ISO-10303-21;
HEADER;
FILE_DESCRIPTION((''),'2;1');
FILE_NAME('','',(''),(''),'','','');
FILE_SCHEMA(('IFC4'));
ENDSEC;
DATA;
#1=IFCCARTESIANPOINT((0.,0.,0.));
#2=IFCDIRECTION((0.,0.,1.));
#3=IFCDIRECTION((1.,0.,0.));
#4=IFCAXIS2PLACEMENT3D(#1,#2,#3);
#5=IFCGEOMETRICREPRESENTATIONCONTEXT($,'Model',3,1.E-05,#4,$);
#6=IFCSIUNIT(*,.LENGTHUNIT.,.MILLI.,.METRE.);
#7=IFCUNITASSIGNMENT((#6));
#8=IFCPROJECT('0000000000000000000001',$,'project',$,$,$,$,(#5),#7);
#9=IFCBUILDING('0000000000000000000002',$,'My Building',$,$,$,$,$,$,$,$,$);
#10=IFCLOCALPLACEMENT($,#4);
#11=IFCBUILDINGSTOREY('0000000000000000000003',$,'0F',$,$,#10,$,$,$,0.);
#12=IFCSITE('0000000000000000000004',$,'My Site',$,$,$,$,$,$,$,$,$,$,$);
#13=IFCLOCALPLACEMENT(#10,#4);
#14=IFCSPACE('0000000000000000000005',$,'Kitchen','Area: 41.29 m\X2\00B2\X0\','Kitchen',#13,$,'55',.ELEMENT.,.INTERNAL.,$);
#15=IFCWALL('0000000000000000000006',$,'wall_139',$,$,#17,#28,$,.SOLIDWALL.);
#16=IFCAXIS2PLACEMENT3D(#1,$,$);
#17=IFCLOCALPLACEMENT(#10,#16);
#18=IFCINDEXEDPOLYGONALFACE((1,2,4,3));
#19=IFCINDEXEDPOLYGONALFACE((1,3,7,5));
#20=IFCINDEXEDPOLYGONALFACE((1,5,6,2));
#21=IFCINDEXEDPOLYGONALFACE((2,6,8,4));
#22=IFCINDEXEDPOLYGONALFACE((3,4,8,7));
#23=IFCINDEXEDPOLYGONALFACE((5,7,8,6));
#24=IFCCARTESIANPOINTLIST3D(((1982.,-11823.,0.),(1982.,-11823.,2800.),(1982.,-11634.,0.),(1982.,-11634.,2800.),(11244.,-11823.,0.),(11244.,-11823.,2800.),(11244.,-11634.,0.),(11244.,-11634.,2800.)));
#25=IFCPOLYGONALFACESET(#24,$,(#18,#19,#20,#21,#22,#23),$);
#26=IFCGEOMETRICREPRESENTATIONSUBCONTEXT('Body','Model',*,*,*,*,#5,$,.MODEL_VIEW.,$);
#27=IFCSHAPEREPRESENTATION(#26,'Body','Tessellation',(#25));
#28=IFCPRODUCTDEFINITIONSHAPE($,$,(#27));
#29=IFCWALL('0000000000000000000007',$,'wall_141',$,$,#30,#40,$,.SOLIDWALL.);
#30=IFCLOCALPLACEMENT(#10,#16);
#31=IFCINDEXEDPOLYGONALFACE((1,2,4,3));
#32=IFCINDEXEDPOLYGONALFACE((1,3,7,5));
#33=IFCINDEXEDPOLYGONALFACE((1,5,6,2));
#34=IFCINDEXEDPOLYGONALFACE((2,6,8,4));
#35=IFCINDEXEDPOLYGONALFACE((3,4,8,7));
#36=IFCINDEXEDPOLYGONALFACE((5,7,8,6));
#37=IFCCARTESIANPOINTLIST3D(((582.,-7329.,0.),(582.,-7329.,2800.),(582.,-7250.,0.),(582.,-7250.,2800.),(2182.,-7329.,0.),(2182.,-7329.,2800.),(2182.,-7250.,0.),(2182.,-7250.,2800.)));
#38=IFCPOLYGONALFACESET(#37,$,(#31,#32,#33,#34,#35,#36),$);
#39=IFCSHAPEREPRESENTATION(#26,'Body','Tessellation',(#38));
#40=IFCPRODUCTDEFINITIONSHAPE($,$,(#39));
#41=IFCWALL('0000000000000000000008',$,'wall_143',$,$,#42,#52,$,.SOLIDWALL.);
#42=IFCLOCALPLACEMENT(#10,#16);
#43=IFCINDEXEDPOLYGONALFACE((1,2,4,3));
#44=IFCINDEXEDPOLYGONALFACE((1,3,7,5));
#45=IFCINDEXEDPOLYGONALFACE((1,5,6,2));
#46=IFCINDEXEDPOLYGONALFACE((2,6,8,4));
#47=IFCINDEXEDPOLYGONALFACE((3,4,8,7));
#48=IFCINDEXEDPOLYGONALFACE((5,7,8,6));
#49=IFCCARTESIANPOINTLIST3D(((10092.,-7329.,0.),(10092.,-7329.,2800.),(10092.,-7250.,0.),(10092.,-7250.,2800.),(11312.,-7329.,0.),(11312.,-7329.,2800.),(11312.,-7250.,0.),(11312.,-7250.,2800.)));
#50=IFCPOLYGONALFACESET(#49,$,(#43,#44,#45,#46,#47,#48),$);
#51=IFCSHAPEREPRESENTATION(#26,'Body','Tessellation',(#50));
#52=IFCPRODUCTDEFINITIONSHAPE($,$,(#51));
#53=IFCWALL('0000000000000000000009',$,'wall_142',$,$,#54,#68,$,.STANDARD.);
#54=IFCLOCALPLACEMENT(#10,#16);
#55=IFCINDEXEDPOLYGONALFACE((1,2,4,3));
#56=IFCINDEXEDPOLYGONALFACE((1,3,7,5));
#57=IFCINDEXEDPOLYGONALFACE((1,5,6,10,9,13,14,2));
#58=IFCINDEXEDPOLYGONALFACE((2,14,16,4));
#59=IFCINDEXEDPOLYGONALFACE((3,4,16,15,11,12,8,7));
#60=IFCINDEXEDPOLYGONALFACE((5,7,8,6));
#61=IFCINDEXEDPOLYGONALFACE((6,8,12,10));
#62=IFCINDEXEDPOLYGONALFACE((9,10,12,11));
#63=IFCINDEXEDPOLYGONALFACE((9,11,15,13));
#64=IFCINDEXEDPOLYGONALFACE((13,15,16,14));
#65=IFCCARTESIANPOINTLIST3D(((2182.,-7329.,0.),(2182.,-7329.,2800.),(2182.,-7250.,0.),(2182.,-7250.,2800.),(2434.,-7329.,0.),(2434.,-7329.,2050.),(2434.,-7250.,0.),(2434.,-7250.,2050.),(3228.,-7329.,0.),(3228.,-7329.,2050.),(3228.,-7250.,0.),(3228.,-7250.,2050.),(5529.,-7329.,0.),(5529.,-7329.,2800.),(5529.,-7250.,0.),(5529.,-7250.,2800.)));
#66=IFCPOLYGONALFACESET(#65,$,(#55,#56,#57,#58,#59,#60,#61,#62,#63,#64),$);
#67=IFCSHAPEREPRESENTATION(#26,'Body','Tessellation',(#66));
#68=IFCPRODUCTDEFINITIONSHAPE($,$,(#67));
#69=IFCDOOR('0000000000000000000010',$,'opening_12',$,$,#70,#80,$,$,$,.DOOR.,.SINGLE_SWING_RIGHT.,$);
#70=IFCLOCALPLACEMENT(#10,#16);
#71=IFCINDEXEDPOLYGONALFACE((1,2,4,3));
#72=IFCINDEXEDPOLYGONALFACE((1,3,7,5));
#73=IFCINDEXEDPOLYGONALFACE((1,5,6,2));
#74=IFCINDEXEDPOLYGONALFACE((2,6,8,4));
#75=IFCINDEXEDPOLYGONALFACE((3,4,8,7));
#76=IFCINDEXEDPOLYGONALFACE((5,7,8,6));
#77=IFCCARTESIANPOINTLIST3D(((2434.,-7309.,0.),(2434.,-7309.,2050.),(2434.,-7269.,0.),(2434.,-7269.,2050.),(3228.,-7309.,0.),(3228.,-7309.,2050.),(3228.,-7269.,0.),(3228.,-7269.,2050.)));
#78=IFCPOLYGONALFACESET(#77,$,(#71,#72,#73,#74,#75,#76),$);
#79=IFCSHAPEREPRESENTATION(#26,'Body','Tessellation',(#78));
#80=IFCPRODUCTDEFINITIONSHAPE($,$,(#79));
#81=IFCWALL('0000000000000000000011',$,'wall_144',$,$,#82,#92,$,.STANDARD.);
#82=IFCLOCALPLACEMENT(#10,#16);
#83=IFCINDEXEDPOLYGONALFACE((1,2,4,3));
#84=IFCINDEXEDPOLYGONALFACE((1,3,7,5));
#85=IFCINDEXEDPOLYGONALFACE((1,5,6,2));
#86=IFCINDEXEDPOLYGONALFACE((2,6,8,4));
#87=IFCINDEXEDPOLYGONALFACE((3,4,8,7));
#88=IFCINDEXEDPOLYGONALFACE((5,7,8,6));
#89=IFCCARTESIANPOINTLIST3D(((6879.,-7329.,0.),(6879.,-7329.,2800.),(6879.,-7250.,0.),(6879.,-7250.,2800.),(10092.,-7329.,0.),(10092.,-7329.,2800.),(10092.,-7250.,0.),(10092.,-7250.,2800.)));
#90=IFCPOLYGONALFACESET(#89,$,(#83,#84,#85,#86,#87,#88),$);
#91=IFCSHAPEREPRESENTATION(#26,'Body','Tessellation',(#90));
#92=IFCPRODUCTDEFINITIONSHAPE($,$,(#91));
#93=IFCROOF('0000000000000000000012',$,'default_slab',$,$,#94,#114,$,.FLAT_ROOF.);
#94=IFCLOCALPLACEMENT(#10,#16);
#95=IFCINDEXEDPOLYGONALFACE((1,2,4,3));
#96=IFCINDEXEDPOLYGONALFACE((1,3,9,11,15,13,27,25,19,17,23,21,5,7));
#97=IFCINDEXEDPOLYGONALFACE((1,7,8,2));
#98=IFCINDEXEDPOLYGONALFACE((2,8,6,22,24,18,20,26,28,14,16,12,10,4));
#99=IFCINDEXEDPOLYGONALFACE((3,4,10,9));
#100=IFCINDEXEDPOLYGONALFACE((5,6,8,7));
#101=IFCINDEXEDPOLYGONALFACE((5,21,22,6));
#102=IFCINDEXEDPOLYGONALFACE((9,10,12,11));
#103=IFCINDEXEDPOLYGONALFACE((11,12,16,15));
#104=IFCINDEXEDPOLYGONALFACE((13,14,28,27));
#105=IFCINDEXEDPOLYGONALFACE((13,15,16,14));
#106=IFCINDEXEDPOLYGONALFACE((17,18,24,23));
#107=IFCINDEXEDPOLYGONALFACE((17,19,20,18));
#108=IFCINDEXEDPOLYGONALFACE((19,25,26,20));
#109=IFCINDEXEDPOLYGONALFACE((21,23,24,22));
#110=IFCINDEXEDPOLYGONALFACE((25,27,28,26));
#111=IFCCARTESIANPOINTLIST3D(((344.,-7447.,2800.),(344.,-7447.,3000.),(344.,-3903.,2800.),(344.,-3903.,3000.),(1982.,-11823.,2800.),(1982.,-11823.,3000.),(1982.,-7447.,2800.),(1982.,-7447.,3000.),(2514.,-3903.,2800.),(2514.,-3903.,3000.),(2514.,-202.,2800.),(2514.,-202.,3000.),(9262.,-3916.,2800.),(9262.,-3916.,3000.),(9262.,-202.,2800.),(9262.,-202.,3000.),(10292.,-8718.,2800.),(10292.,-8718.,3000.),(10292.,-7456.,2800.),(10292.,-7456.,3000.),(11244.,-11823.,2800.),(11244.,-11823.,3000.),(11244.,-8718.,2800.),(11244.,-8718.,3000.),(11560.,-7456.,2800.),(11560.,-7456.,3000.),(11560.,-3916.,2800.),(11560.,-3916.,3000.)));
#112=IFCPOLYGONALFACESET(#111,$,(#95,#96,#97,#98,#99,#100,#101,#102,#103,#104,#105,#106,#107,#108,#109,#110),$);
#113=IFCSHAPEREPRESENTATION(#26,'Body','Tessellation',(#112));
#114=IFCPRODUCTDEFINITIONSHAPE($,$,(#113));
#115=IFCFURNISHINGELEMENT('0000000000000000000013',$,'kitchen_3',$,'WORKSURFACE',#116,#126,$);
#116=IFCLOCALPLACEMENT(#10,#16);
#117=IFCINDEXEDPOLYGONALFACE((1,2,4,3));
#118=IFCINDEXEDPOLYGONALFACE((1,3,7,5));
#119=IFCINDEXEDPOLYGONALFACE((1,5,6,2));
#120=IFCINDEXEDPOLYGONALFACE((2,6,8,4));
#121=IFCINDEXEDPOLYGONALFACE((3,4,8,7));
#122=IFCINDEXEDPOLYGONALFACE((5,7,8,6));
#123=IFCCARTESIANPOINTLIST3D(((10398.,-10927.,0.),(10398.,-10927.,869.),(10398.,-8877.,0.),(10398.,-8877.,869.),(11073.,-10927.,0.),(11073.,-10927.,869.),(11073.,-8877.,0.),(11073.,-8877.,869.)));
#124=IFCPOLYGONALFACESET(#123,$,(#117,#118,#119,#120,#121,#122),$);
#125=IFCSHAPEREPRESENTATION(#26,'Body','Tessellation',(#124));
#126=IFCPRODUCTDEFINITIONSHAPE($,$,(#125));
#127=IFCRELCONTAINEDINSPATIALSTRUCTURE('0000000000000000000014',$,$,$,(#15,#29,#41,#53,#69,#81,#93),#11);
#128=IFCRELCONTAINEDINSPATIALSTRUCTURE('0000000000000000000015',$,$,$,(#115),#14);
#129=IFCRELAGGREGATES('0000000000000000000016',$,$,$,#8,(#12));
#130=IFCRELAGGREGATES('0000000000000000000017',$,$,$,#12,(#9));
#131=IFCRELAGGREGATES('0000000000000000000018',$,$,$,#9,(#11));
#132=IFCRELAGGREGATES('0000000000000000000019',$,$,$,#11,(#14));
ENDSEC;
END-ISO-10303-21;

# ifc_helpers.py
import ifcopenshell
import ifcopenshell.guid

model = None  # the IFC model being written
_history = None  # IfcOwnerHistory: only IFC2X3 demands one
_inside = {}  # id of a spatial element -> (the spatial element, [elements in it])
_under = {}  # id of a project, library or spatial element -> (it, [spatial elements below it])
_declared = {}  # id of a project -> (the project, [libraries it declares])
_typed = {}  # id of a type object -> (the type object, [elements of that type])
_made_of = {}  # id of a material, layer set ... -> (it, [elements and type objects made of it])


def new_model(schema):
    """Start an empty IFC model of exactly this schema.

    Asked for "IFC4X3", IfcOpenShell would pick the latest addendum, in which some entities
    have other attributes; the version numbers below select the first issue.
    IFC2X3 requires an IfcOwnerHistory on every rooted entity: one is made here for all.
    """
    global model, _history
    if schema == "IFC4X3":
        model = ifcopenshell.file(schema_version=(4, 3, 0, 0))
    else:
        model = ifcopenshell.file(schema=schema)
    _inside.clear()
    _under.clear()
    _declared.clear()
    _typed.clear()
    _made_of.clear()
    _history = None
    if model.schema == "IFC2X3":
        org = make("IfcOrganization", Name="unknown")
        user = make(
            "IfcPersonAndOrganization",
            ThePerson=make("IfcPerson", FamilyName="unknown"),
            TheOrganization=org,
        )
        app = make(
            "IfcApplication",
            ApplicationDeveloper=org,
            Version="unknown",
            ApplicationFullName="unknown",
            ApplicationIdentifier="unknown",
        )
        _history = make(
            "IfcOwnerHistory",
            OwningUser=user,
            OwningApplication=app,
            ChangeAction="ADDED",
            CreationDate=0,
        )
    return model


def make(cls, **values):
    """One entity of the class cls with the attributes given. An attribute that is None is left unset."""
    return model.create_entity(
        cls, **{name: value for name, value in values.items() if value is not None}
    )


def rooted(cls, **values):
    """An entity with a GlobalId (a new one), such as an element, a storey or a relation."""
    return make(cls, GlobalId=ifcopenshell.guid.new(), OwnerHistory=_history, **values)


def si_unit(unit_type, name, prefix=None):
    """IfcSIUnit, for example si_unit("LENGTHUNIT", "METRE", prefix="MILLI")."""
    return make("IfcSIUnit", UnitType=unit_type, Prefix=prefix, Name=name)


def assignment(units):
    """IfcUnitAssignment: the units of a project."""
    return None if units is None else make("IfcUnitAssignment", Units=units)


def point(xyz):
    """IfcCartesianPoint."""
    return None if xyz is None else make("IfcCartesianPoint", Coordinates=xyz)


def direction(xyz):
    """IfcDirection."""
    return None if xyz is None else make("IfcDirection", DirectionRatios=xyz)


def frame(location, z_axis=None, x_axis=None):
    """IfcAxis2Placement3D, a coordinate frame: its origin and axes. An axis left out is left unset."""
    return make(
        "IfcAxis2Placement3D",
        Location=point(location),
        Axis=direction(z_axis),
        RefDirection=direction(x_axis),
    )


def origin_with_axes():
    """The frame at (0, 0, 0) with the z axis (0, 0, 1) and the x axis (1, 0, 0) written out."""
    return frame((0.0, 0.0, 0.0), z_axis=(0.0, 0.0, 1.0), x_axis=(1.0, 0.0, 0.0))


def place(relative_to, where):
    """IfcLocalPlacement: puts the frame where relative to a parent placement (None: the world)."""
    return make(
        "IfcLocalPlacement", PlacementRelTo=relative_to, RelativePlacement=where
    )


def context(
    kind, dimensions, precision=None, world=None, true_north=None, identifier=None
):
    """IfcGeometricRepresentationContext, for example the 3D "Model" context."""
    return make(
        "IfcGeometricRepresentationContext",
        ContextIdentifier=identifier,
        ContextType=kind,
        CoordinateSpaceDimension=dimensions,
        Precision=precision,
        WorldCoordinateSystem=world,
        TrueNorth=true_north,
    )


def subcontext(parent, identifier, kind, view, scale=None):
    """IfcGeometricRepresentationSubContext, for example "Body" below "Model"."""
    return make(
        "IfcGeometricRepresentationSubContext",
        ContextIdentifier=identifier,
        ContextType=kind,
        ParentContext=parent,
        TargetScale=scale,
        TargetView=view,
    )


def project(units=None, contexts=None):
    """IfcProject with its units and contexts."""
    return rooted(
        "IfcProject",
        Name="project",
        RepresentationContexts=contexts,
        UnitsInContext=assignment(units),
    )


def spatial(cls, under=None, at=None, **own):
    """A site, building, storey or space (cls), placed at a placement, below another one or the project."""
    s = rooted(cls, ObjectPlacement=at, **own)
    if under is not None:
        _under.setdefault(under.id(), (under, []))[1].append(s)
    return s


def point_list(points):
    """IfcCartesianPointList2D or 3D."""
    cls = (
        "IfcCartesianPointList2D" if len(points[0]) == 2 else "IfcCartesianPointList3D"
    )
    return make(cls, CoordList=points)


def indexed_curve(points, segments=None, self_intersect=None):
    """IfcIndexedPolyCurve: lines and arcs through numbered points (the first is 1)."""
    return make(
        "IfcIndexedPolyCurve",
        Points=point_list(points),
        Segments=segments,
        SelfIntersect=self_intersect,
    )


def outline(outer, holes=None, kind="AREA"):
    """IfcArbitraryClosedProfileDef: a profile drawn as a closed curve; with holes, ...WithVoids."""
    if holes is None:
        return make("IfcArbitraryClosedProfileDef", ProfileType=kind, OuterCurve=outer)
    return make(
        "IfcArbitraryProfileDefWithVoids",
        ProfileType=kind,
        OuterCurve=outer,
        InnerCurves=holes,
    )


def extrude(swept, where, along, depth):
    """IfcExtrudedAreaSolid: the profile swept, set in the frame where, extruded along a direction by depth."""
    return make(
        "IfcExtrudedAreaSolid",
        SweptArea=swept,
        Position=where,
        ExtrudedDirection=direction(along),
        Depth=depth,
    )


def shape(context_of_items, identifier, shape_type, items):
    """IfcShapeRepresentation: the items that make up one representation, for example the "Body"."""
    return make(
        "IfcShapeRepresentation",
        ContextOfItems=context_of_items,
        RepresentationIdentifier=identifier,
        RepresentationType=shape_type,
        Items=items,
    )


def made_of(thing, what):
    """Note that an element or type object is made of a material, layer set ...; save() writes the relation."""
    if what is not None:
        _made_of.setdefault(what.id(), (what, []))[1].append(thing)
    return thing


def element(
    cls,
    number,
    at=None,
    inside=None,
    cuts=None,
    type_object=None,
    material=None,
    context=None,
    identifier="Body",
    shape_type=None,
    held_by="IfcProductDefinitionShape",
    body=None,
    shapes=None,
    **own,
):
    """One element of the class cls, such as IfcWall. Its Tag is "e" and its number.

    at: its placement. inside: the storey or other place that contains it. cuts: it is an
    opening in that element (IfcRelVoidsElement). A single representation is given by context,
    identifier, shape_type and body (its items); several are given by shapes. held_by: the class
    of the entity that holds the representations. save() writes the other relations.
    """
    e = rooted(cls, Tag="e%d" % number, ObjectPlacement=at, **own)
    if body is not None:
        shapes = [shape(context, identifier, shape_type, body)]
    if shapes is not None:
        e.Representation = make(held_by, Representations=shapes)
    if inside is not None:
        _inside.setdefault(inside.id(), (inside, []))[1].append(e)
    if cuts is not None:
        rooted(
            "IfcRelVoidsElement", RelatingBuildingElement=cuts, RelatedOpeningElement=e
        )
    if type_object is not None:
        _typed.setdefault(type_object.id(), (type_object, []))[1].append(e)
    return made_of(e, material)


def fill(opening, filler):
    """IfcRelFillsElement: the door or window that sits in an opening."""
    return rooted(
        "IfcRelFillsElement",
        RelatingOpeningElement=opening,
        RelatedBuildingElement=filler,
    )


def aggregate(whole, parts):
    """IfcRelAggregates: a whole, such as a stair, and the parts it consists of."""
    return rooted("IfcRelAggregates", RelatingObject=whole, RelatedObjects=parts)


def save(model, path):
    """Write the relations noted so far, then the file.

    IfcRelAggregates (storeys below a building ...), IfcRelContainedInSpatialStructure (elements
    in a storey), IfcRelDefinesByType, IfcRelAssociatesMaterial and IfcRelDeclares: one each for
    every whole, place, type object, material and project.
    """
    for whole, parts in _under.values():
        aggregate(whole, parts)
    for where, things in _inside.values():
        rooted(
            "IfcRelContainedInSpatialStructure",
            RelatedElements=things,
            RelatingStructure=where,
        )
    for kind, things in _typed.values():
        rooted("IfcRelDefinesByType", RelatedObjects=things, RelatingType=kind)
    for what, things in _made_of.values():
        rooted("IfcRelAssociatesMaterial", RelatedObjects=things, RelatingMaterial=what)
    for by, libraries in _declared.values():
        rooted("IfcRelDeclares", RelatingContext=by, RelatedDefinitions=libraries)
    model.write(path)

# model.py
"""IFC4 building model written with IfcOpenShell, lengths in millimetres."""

from ifc_helpers import new_model, si_unit, frame, origin_with_axes, place, context, subcontext, project, spatial, indexed_curve, outline, extrude, element, fill, save


model = new_model("IFC4")

# Units and contexts
model_context_1 = context("Model", 3, precision=1e-05, world=origin_with_axes())
body_context_1 = subcontext(model_context_1, "Body", "Model", "MODEL_VIEW")
ifc_project = project(units=[si_unit("LENGTHUNIT", "METRE", prefix="MILLI")], contexts=[model_context_1])

# Site, building, storey
site = spatial("IfcSite", under=ifc_project, Name="My Site")
building = spatial("IfcBuilding", under=site, Name="My Building")
storey_placement = place(None, origin_with_axes())
storey = spatial("IfcBuildingStorey", under=building, at=storey_placement, Name="0F", Elevation=0.0)

# Walls
wall_1_placement = place(storey_placement, origin_with_axes())
element("IfcWall", 1, at=wall_1_placement, inside=storey, Name="wall_139", PredefinedType="SOLIDWALL", context=body_context_1, shape_type="SweptSolid", body=[
    extrude(outline(indexed_curve([(1982.0, -11823.0), (11244.0, -11823.0), (11244.0, -11634.0), (1982.0, -11634.0), (1982.0, -11823.0)])), None, (0.0, 0.0, 1.0), 2800.0),
])
wall_2_placement = place(storey_placement, origin_with_axes())
element("IfcWall", 2, at=wall_2_placement, inside=storey, Name="wall_141", PredefinedType="SOLIDWALL", context=body_context_1, shape_type="SweptSolid", body=[
    extrude(outline(indexed_curve([(582.0, -7329.0), (2182.0, -7329.0), (2182.0, -7250.0), (582.0, -7250.0), (582.0, -7329.0)])), None, (0.0, 0.0, 1.0), 2800.0),
])
wall_3_placement = place(storey_placement, origin_with_axes())
element("IfcWall", 3, at=wall_3_placement, inside=storey, Name="wall_143", PredefinedType="SOLIDWALL", context=body_context_1, shape_type="SweptSolid", body=[
    extrude(outline(indexed_curve([(10092.0, -7329.0), (11312.0, -7329.0), (11312.0, -7250.0), (10092.0, -7250.0), (10092.0, -7329.0)])), None, (0.0, 0.0, 1.0), 2800.0),
])

# Wall, opening, door
wall_4_placement = place(storey_placement, origin_with_axes())
wall_4 = element("IfcWall", 4, at=wall_4_placement, inside=storey, Name="wall_142", PredefinedType="STANDARD", context=body_context_1, shape_type="SweptSolid", body=[
    extrude(outline(indexed_curve([(2182.0, -7329.0), (5529.0, -7329.0), (5529.0, -7250.0), (2182.0, -7250.0), (2182.0, -7329.0)])), None, (0.0, 0.0, 1.0), 2800.0),
])
opening_1_placement = place(wall_4_placement, origin_with_axes())
opening_1 = element("IfcOpeningElement", 5, at=opening_1_placement, cuts=wall_4, ObjectType="Opening", context=body_context_1, shape_type="SweptSolid", body=[
    extrude(outline(indexed_curve([(3228.0, -7395.0), (3228.0, -7183.0), (2434.0, -7183.0), (2434.0, -7395.0), (3228.0, -7395.0)])), None, (0.0, 0.0, 1.0), 2050.0),
])
door_1_placement = place(opening_1_placement, origin_with_axes())
door_1 = element("IfcDoor", 6, at=door_1_placement, inside=storey, Name="opening_12", OperationType="SINGLE_SWING_RIGHT", PredefinedType="DOOR", context=body_context_1, shape_type="SweptSolid", body=[
    extrude(outline(indexed_curve([(3228.0, -7309.0), (3228.0, -7269.0), (2434.0, -7269.0), (2434.0, -7309.0), (3228.0, -7309.0)])), None, (0.0, 0.0, 1.0), 2050.0),
])
fill(opening_1, door_1)

# Wall
wall_5_placement = place(storey_placement, origin_with_axes())
element("IfcWall", 7, at=wall_5_placement, inside=storey, Name="wall_144", PredefinedType="STANDARD", context=body_context_1, shape_type="SweptSolid", body=[
    extrude(outline(indexed_curve([(6879.0, -7329.0), (10092.0, -7329.0), (10092.0, -7250.0), (6879.0, -7250.0), (6879.0, -7329.0)])), None, (0.0, 0.0, 1.0), 2800.0),
])

# Roof
roof_placement = place(storey_placement, frame((0.0, 0.0, 3000.0), z_axis=(0.0, 0.0, 1.0), x_axis=(1.0, 0.0, 0.0)))
element("IfcRoof", 8, at=roof_placement, inside=storey, Name="default_slab", PredefinedType="FLAT_ROOF", context=body_context_1, shape_type="SweptSolid", body=[
    extrude(outline(indexed_curve([(1982.0, -11823.0), (11244.0, -11823.0), (11244.0, -8718.0), (10292.0, -8718.0), (10292.0, -7456.0), (11560.0, -7456.0), (11560.0, -3916.0), (9262.0, -3916.0), (9262.0, -202.0), (2514.0, -202.0), (2514.0, -3903.0), (344.0, -3903.0), (344.0, -7447.0), (1982.0, -7447.0), (1982.0, -11823.0)])), None, (0.0, 0.0, -1.0), 200.0),
])

# Shared definitions
space_1_placement = place(storey_placement, origin_with_axes())
space_1 = spatial("IfcSpace", under=storey, at=space_1_placement, Name="Kitchen", Description="Area: 41.29 m²", ObjectType="Kitchen", LongName="55", CompositionType="ELEMENT", PredefinedType="INTERNAL")

# Furnishing element
furnishing_1_placement = place(space_1_placement, origin_with_axes())
element("IfcFurnishingElement", 9, at=furnishing_1_placement, inside=space_1, Name="kitchen_3", ObjectType="WORKSURFACE", context=body_context_1, shape_type="SweptSolid", body=[
    extrude(outline(indexed_curve([(10398.0, -8877.0), (11073.0, -8877.0), (11073.0, -10927.0), (10398.0, -10927.0), (10398.0, -8877.0)])), None, (0.0, 0.0, 1.0), 869.0),
])

save(model, "model.ifc")
